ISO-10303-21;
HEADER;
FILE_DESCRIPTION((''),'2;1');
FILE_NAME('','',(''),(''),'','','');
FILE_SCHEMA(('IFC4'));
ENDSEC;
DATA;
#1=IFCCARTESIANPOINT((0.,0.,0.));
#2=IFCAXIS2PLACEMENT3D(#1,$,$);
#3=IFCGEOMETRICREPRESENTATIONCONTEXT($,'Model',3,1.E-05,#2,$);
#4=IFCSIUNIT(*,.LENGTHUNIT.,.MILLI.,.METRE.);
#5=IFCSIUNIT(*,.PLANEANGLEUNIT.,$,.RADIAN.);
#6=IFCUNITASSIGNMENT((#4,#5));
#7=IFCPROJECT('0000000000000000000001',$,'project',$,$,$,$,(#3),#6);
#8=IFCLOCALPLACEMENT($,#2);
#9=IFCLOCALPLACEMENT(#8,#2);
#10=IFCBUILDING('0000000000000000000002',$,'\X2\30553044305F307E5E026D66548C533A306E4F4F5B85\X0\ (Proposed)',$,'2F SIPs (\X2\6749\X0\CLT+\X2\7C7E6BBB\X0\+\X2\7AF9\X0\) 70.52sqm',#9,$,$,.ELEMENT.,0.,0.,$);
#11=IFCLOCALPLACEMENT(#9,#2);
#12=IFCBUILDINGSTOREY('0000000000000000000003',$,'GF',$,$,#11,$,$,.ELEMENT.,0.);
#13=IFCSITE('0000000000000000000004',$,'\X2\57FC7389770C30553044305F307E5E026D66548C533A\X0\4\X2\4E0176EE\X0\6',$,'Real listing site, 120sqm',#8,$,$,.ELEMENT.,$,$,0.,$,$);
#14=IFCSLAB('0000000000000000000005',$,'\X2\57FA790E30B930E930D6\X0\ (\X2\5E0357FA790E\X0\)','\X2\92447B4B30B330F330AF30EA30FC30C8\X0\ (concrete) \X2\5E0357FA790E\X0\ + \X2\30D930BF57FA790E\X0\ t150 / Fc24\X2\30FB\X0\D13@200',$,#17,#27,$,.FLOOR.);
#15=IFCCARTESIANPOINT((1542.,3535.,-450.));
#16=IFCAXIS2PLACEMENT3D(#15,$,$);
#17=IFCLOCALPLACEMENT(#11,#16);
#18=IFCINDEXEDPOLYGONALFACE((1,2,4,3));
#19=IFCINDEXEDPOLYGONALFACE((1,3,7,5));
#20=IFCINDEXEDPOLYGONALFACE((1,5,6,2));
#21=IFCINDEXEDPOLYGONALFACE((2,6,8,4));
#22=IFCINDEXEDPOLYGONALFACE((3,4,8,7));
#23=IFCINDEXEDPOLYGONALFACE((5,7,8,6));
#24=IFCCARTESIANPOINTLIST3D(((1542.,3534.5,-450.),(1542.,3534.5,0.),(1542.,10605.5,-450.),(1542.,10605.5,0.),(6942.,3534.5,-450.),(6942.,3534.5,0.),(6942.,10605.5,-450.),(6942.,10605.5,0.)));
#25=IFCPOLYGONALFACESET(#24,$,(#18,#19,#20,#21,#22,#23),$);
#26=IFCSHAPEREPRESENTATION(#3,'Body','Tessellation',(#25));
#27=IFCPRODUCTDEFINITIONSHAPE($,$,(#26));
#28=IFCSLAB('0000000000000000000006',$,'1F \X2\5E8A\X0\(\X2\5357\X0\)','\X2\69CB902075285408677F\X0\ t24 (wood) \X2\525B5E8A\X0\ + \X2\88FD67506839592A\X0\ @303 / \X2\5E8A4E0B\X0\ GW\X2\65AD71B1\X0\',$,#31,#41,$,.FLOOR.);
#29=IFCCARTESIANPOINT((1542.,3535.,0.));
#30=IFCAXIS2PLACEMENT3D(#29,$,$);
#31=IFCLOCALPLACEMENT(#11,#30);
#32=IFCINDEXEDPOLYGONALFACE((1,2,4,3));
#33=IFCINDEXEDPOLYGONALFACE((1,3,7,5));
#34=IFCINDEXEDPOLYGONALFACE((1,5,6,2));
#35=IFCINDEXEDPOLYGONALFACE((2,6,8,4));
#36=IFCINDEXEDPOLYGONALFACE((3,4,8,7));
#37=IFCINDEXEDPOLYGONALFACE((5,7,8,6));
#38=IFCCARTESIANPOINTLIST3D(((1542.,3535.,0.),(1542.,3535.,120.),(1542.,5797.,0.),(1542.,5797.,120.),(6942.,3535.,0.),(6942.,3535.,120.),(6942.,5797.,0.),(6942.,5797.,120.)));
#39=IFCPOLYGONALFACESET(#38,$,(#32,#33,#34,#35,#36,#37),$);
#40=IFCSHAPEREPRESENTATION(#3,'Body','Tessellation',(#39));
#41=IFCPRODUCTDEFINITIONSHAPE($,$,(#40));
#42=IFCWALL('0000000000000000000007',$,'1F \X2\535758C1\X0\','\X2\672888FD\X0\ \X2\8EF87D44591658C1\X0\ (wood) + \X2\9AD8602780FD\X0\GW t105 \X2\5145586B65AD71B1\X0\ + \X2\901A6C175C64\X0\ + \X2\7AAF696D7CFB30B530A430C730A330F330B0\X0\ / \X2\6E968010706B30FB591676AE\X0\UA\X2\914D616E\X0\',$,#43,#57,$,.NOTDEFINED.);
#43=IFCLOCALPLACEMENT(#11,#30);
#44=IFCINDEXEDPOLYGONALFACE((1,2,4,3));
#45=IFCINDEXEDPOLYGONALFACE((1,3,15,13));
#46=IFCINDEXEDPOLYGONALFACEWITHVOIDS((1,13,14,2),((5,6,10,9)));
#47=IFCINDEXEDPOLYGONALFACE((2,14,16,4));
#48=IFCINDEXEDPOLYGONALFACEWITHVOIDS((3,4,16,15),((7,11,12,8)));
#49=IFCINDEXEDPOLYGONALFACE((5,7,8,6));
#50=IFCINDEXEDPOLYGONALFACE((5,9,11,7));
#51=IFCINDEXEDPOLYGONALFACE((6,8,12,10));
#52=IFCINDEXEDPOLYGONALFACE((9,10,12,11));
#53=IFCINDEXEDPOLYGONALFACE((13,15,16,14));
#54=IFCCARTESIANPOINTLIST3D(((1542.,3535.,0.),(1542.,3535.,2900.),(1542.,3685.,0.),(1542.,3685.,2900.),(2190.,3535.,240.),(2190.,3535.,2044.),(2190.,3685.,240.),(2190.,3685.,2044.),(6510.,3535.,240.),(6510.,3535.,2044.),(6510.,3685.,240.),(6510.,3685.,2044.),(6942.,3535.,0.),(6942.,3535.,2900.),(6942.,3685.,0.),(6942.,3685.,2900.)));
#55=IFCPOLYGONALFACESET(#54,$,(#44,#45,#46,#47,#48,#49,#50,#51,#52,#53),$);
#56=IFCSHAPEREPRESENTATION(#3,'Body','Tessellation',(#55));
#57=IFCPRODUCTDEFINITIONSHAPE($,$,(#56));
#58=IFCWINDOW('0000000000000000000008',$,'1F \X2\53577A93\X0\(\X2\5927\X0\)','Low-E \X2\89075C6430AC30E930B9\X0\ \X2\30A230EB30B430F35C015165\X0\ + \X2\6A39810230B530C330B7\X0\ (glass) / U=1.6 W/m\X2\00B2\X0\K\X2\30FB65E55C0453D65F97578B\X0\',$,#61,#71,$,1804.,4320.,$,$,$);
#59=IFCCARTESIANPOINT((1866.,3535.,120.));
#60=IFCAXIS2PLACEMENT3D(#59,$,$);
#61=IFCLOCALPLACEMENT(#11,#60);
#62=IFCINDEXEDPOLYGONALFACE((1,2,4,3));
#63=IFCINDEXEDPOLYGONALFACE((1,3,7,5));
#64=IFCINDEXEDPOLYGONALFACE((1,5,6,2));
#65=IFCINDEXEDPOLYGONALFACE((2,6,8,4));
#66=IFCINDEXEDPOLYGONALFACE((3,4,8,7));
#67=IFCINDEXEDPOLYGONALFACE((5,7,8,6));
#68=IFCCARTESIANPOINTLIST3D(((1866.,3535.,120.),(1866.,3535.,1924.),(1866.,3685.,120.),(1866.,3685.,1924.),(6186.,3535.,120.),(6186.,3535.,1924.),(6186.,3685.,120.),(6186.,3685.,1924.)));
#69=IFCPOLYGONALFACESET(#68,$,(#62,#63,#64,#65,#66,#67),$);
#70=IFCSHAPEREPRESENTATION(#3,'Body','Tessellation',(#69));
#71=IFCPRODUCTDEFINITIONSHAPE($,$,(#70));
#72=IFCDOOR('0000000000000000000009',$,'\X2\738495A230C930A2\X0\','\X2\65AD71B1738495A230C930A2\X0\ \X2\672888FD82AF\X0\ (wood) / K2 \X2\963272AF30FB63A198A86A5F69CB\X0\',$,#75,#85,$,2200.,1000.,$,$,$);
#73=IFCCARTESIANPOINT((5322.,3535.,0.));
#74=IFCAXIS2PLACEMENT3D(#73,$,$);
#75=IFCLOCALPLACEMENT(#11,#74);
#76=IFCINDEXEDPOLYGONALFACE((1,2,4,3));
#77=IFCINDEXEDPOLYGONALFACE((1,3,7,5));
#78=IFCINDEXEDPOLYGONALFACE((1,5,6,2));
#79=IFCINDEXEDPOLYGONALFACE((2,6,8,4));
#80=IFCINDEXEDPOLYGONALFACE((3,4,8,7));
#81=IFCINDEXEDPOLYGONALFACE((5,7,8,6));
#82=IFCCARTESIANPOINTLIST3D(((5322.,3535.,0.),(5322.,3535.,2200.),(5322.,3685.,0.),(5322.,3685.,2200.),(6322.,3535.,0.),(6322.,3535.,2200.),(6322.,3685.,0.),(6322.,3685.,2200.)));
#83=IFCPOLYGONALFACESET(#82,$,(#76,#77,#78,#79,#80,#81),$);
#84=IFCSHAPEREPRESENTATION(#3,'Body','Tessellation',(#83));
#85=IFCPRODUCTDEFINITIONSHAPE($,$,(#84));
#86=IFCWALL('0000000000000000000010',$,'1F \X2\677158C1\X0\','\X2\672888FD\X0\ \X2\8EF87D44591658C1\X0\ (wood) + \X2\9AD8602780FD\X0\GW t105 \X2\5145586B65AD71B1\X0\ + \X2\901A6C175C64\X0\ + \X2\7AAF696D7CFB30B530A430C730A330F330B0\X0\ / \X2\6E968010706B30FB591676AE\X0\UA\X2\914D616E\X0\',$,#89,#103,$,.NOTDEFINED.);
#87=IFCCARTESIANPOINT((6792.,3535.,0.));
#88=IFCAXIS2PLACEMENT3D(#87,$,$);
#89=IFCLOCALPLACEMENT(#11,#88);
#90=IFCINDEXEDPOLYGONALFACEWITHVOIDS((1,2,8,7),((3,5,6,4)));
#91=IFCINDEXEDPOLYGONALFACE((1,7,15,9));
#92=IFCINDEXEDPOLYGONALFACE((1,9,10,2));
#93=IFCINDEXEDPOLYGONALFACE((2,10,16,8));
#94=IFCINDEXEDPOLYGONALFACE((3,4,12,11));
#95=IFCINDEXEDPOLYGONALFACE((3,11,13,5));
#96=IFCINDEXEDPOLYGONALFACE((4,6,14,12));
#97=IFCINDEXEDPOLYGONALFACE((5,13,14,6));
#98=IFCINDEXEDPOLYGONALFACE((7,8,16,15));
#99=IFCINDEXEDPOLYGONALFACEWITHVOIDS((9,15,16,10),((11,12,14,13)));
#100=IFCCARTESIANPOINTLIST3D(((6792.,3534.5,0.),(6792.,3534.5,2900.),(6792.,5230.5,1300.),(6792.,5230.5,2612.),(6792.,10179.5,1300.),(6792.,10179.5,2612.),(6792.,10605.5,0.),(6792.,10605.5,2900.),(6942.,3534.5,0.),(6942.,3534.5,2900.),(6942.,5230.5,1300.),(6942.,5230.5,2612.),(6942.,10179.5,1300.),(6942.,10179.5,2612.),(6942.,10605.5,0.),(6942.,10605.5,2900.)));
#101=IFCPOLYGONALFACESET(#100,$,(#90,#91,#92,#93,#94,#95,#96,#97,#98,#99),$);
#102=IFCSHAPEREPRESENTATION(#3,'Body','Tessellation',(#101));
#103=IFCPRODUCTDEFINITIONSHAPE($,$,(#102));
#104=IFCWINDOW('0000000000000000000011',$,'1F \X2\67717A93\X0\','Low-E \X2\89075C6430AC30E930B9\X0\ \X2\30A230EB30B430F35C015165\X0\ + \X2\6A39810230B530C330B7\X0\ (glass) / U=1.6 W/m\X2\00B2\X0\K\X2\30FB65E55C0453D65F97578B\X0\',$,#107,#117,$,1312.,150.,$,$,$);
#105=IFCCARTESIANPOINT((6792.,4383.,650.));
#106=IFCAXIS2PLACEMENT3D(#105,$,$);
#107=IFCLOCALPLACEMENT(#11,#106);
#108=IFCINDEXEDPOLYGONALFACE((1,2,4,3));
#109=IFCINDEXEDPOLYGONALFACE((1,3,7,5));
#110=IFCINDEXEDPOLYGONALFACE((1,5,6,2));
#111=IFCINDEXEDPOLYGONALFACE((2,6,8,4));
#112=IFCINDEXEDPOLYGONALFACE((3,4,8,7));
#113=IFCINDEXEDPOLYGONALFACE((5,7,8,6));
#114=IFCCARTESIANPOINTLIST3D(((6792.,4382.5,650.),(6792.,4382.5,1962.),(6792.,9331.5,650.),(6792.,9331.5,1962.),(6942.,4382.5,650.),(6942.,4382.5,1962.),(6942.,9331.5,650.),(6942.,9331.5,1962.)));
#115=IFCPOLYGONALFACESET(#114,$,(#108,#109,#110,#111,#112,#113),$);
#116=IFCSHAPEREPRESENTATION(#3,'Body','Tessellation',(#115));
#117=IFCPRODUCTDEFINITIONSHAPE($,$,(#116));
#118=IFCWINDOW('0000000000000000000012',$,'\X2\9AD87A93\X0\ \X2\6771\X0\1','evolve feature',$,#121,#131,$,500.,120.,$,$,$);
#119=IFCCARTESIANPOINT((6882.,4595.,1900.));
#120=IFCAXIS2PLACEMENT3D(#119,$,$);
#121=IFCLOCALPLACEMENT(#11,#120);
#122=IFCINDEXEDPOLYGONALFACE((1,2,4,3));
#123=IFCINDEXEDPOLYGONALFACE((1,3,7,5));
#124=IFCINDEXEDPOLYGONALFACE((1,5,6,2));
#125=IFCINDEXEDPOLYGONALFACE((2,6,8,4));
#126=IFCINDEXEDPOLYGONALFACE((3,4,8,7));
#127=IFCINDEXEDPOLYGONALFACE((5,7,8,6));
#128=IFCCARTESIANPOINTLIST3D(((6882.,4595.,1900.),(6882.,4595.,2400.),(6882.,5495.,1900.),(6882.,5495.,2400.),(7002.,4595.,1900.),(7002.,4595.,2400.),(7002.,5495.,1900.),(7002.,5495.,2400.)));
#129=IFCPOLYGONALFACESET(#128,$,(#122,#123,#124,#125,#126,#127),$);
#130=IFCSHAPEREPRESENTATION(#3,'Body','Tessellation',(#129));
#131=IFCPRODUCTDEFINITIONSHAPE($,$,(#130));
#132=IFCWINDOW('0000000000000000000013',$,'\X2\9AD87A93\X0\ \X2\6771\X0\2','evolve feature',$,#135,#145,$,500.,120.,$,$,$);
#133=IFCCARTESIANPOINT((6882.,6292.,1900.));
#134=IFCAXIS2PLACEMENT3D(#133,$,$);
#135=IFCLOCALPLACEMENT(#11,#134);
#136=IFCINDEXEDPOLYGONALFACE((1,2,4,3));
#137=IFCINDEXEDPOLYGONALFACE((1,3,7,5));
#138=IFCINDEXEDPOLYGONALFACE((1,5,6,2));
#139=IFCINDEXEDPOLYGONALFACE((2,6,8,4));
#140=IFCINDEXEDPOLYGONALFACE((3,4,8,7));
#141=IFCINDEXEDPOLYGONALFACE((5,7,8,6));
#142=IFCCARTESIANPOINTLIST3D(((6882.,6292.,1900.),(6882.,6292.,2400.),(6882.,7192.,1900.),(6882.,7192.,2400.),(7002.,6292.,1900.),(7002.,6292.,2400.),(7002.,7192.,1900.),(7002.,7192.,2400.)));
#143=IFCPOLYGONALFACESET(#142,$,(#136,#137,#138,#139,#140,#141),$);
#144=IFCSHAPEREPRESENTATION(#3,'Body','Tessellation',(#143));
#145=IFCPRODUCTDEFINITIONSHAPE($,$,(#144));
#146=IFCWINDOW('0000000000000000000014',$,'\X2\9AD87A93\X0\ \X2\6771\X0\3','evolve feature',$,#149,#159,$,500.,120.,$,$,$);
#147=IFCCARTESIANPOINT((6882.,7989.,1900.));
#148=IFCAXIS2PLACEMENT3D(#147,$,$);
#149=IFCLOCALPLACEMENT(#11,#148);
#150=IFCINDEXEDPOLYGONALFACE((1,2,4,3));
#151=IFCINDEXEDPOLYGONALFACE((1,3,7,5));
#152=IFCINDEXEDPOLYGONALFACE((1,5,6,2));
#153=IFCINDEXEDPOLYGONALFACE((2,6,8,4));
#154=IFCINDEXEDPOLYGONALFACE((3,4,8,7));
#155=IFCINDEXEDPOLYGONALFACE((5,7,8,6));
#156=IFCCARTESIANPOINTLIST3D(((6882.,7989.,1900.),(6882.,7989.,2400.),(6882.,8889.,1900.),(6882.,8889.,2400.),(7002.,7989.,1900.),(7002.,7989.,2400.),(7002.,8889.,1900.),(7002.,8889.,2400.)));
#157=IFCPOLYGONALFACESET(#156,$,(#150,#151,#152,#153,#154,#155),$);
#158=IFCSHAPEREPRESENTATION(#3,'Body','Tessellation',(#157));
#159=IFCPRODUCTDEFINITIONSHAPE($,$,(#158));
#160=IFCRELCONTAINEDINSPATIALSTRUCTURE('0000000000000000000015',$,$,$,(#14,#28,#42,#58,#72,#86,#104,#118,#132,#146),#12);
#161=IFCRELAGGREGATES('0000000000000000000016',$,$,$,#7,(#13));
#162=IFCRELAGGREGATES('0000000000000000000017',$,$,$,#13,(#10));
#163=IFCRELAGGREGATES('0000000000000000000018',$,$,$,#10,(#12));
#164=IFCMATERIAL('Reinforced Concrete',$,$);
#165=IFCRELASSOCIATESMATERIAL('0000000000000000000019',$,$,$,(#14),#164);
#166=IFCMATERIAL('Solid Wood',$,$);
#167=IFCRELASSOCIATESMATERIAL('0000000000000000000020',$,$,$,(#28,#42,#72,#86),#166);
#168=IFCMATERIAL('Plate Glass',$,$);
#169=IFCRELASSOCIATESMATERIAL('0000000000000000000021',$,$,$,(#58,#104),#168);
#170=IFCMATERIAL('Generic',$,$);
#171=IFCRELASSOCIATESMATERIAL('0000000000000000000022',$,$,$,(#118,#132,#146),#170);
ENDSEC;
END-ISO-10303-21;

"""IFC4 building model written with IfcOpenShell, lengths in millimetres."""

from ifc_helpers import new_model, si_unit, frame, frame_2d, origin, place, context, project, spatial, rectangle, extrude, material, element, fill, save


model = new_model("IFC4")

# Units and contexts
model_context = context("Model", 3, precision=1e-05, world=origin())
ifc_project = project(units=[si_unit("LENGTHUNIT", "METRE", prefix="MILLI"), si_unit("PLANEANGLEUNIT", "RADIAN")], contexts=[model_context])

# Site, building, storey
site_placement = place(None, origin())
site = spatial("IfcSite", under=ifc_project, at=site_placement, Name="埼玉県さいたま市浦和区4丁目6", ObjectType="Real listing site, 120sqm", CompositionType="ELEMENT", RefElevation=0.0)
building_placement = place(site_placement, origin())
building = spatial("IfcBuilding", under=site, at=building_placement, Name="さいたま市浦和区の住宅 (Proposed)", ObjectType="2F SIPs (杉CLT+籾殻+竹) 70.52sqm", CompositionType="ELEMENT", ElevationOfRefHeight=0.0, ElevationOfTerrain=0.0)
storey_placement = place(building_placement, origin())
storey = spatial("IfcBuildingStorey", under=building, at=storey_placement, Name="GF", CompositionType="ELEMENT", Elevation=0.0)

# Slabs
ifc_material_1 = material(Name="Reinforced Concrete")
slab_1_placement = place(storey_placement, frame((1542.0, 3535.0, -450.0)))
element("IfcSlab", 1, at=slab_1_placement, inside=storey, material=ifc_material_1, Name="基礎スラブ (布基礎)", Description="鉄筋コンクリート (concrete) 布基礎 + ベタ基礎 t150 / Fc24・D13@200", PredefinedType="FLOOR", context=model_context, shape_type="SweptSolid", body=[
    extrude(rectangle(XDim=5400.0, YDim=7071.0, at=frame_2d((2700.0, 3535.0))), frame((1542.0, 3535.0, -450.0)), (0.0, 0.0, 1.0), 450.0),
])
ifc_material_2 = material(Name="Solid Wood")
slab_2_placement = place(storey_placement, frame((1542.0, 3535.0, 0.0)))
element("IfcSlab", 2, at=slab_2_placement, inside=storey, material=ifc_material_2, Name="1F 床(南)", Description="構造用合板 t24 (wood) 剛床 + 製材根太 @303 / 床下 GW断熱", PredefinedType="FLOOR", context=model_context, shape_type="SweptSolid", body=[
    extrude(rectangle(XDim=5400.0, YDim=2262.0, at=frame_2d((2700.0, 1131.0))), frame((1542.0, 3535.0, 0.0)), (0.0, 0.0, 1.0), 120.0),
])

# Wall, openings, window, door
wall_1_placement = place(storey_placement, frame((1542.0, 3535.0, 0.0)))
wall_1 = element("IfcWall", 3, at=wall_1_placement, inside=storey, material=ifc_material_2, Name="1F 南壁", Description="木製 軸組外壁 (wood) + 高性能GW t105 充填断熱 + 通気層 + 窯業系サイディング / 準耐火・外皮UA配慮", PredefinedType="NOTDEFINED", context=model_context, shape_type="SweptSolid", body=[
    extrude(rectangle(XDim=5400.0, YDim=150.0, at=frame_2d((2700.0, 75.0))), frame((1542.0, 3535.0, 0.0)), (0.0, 0.0, 1.0), 2900.0),
])
opening_1_placement = place(storey_placement, frame((1866.0, 3535.0, 120.0)))
opening_1 = element("IfcOpeningElement", 4, at=opening_1_placement, cuts=wall_1, PredefinedType="NOTDEFINED", context=model_context, shape_type="SweptSolid", body=[
    extrude(rectangle(XDim=4320.0, YDim=150.0, at=frame_2d((2160.0, 75.0))), frame((1866.0, 3535.0, 120.0)), (0.0, 0.0, 1.0), 1804.0),
])
opening_2_placement = place(storey_placement, frame((5322.0, 3535.0, 0.0)))
opening_2 = element("IfcOpeningElement", 5, at=opening_2_placement, cuts=wall_1, PredefinedType="NOTDEFINED", context=model_context, shape_type="SweptSolid", body=[
    extrude(rectangle(XDim=1000.0, YDim=150.0, at=frame_2d((500.0, 75.0))), frame((5322.0, 3535.0, 0.0)), (0.0, 0.0, 1.0), 2200.0),
])
ifc_material_3 = material(Name="Plate Glass")
window_1_placement = place(storey_placement, frame((1866.0, 3535.0, 120.0)))
window_1 = element("IfcWindow", 6, at=window_1_placement, inside=storey, material=ifc_material_3, Name="1F 南窓(大)", Description="Low-E 複層ガラス アルゴン封入 + 樹脂サッシ (glass) / U=1.6 W/m²K・日射取得型", OverallHeight=1804.0, OverallWidth=4320.0, context=model_context, shape_type="SweptSolid", body=[
    extrude(rectangle(XDim=4320.0, YDim=150.0, at=frame_2d((2160.0, 75.0))), frame((1866.0, 3535.0, 120.0)), (0.0, 0.0, 1.0), 1804.0),
])
fill(opening_1, window_1)
door_placement = place(storey_placement, frame((5322.0, 3535.0, 0.0)))
door = element("IfcDoor", 7, at=door_placement, inside=storey, material=ifc_material_2, Name="玄関ドア", Description="断熱玄関ドア 木製芯 (wood) / K2 防犯・採風機構", OverallHeight=2200.0, OverallWidth=1000.0, context=model_context, shape_type="SweptSolid", body=[
    extrude(rectangle(XDim=1000.0, YDim=150.0, at=frame_2d((500.0, 75.0))), frame((5322.0, 3535.0, 0.0)), (0.0, 0.0, 1.0), 2200.0),
])
fill(opening_2, door)

# Wall, openings, windows
wall_2_placement = place(storey_placement, frame((6792.0, 3535.0, 0.0)))
wall_2 = element("IfcWall", 8, at=wall_2_placement, inside=storey, material=ifc_material_2, Name="1F 東壁", Description="木製 軸組外壁 (wood) + 高性能GW t105 充填断熱 + 通気層 + 窯業系サイディング / 準耐火・外皮UA配慮", PredefinedType="NOTDEFINED", context=model_context, shape_type="SweptSolid", body=[
    extrude(rectangle(XDim=150.0, YDim=7071.0, at=frame_2d((75.0, 3535.0))), frame((6792.0, 3535.0, 0.0)), (0.0, 0.0, 1.0), 2900.0),
])
opening_3_placement = place(storey_placement, frame((6792.0, 4383.0, 650.0)))
opening_3 = element("IfcOpeningElement", 9, at=opening_3_placement, cuts=wall_2, PredefinedType="NOTDEFINED", context=model_context, shape_type="SweptSolid", body=[
    extrude(rectangle(XDim=150.0, YDim=4949.0, at=frame_2d((75.0, 2474.0))), frame((6792.0, 4383.0, 650.0)), (0.0, 0.0, 1.0), 1312.0),
])
opening_4_placement = place(storey_placement, frame((6882.0, 4595.0, 1900.0)))
opening_4 = element("IfcOpeningElement", 10, at=opening_4_placement, cuts=wall_2, PredefinedType="NOTDEFINED", context=model_context, shape_type="SweptSolid", body=[
    extrude(rectangle(XDim=120.0, YDim=900.0, at=frame_2d((60.0, 450.0))), frame((6882.0, 4595.0, 1900.0)), (0.0, 0.0, 1.0), 500.0),
])
opening_5_placement = place(storey_placement, frame((6882.0, 6292.0, 1900.0)))
opening_5 = element("IfcOpeningElement", 11, at=opening_5_placement, cuts=wall_2, PredefinedType="NOTDEFINED", context=model_context, shape_type="SweptSolid", body=[
    extrude(rectangle(XDim=120.0, YDim=900.0, at=frame_2d((60.0, 450.0))), frame((6882.0, 6292.0, 1900.0)), (0.0, 0.0, 1.0), 500.0),
])
opening_6_placement = place(storey_placement, frame((6882.0, 7989.0, 1900.0)))
opening_6 = element("IfcOpeningElement", 12, at=opening_6_placement, cuts=wall_2, PredefinedType="NOTDEFINED", context=model_context, shape_type="SweptSolid", body=[
    extrude(rectangle(XDim=120.0, YDim=900.0, at=frame_2d((60.0, 450.0))), frame((6882.0, 7989.0, 1900.0)), (0.0, 0.0, 1.0), 500.0),
])
window_2_placement = place(storey_placement, frame((6792.0, 4383.0, 650.0)))
window_2 = element("IfcWindow", 13, at=window_2_placement, inside=storey, material=ifc_material_3, Name="1F 東窓", Description="Low-E 複層ガラス アルゴン封入 + 樹脂サッシ (glass) / U=1.6 W/m²K・日射取得型", OverallHeight=1312.0, OverallWidth=150.0, context=model_context, shape_type="SweptSolid", body=[
    extrude(rectangle(XDim=150.0, YDim=4949.0, at=frame_2d((75.0, 2474.0))), frame((6792.0, 4383.0, 650.0)), (0.0, 0.0, 1.0), 1312.0),
])
fill(opening_3, window_2)
ifc_material_4 = material(Name="Generic")
window_3_placement = place(storey_placement, frame((6882.0, 4595.0, 1900.0)))
window_3 = element("IfcWindow", 14, at=window_3_placement, inside=storey, material=ifc_material_4, Name="高窓 東1", Description="evolve feature", OverallHeight=500.0, OverallWidth=120.0, context=model_context, shape_type="SweptSolid", body=[
    extrude(rectangle(XDim=120.0, YDim=900.0, at=frame_2d((60.0, 450.0))), frame((6882.0, 4595.0, 1900.0)), (0.0, 0.0, 1.0), 500.0),
])
fill(opening_4, window_3)
window_4_placement = place(storey_placement, frame((6882.0, 6292.0, 1900.0)))
window_4 = element("IfcWindow", 15, at=window_4_placement, inside=storey, material=ifc_material_4, Name="高窓 東2", Description="evolve feature", OverallHeight=500.0, OverallWidth=120.0, context=model_context, shape_type="SweptSolid", body=[
    extrude(rectangle(XDim=120.0, YDim=900.0, at=frame_2d((60.0, 450.0))), frame((6882.0, 6292.0, 1900.0)), (0.0, 0.0, 1.0), 500.0),
])
fill(opening_5, window_4)
window_5_placement = place(storey_placement, frame((6882.0, 7989.0, 1900.0)))
window_5 = element("IfcWindow", 16, at=window_5_placement, inside=storey, material=ifc_material_4, Name="高窓 東3", Description="evolve feature", OverallHeight=500.0, OverallWidth=120.0, context=model_context, shape_type="SweptSolid", body=[
    extrude(rectangle(XDim=120.0, YDim=900.0, at=frame_2d((60.0, 450.0))), frame((6882.0, 7989.0, 1900.0)), (0.0, 0.0, 1.0), 500.0),
])
fill(opening_6, window_5)

save(model, "model.ifc")
